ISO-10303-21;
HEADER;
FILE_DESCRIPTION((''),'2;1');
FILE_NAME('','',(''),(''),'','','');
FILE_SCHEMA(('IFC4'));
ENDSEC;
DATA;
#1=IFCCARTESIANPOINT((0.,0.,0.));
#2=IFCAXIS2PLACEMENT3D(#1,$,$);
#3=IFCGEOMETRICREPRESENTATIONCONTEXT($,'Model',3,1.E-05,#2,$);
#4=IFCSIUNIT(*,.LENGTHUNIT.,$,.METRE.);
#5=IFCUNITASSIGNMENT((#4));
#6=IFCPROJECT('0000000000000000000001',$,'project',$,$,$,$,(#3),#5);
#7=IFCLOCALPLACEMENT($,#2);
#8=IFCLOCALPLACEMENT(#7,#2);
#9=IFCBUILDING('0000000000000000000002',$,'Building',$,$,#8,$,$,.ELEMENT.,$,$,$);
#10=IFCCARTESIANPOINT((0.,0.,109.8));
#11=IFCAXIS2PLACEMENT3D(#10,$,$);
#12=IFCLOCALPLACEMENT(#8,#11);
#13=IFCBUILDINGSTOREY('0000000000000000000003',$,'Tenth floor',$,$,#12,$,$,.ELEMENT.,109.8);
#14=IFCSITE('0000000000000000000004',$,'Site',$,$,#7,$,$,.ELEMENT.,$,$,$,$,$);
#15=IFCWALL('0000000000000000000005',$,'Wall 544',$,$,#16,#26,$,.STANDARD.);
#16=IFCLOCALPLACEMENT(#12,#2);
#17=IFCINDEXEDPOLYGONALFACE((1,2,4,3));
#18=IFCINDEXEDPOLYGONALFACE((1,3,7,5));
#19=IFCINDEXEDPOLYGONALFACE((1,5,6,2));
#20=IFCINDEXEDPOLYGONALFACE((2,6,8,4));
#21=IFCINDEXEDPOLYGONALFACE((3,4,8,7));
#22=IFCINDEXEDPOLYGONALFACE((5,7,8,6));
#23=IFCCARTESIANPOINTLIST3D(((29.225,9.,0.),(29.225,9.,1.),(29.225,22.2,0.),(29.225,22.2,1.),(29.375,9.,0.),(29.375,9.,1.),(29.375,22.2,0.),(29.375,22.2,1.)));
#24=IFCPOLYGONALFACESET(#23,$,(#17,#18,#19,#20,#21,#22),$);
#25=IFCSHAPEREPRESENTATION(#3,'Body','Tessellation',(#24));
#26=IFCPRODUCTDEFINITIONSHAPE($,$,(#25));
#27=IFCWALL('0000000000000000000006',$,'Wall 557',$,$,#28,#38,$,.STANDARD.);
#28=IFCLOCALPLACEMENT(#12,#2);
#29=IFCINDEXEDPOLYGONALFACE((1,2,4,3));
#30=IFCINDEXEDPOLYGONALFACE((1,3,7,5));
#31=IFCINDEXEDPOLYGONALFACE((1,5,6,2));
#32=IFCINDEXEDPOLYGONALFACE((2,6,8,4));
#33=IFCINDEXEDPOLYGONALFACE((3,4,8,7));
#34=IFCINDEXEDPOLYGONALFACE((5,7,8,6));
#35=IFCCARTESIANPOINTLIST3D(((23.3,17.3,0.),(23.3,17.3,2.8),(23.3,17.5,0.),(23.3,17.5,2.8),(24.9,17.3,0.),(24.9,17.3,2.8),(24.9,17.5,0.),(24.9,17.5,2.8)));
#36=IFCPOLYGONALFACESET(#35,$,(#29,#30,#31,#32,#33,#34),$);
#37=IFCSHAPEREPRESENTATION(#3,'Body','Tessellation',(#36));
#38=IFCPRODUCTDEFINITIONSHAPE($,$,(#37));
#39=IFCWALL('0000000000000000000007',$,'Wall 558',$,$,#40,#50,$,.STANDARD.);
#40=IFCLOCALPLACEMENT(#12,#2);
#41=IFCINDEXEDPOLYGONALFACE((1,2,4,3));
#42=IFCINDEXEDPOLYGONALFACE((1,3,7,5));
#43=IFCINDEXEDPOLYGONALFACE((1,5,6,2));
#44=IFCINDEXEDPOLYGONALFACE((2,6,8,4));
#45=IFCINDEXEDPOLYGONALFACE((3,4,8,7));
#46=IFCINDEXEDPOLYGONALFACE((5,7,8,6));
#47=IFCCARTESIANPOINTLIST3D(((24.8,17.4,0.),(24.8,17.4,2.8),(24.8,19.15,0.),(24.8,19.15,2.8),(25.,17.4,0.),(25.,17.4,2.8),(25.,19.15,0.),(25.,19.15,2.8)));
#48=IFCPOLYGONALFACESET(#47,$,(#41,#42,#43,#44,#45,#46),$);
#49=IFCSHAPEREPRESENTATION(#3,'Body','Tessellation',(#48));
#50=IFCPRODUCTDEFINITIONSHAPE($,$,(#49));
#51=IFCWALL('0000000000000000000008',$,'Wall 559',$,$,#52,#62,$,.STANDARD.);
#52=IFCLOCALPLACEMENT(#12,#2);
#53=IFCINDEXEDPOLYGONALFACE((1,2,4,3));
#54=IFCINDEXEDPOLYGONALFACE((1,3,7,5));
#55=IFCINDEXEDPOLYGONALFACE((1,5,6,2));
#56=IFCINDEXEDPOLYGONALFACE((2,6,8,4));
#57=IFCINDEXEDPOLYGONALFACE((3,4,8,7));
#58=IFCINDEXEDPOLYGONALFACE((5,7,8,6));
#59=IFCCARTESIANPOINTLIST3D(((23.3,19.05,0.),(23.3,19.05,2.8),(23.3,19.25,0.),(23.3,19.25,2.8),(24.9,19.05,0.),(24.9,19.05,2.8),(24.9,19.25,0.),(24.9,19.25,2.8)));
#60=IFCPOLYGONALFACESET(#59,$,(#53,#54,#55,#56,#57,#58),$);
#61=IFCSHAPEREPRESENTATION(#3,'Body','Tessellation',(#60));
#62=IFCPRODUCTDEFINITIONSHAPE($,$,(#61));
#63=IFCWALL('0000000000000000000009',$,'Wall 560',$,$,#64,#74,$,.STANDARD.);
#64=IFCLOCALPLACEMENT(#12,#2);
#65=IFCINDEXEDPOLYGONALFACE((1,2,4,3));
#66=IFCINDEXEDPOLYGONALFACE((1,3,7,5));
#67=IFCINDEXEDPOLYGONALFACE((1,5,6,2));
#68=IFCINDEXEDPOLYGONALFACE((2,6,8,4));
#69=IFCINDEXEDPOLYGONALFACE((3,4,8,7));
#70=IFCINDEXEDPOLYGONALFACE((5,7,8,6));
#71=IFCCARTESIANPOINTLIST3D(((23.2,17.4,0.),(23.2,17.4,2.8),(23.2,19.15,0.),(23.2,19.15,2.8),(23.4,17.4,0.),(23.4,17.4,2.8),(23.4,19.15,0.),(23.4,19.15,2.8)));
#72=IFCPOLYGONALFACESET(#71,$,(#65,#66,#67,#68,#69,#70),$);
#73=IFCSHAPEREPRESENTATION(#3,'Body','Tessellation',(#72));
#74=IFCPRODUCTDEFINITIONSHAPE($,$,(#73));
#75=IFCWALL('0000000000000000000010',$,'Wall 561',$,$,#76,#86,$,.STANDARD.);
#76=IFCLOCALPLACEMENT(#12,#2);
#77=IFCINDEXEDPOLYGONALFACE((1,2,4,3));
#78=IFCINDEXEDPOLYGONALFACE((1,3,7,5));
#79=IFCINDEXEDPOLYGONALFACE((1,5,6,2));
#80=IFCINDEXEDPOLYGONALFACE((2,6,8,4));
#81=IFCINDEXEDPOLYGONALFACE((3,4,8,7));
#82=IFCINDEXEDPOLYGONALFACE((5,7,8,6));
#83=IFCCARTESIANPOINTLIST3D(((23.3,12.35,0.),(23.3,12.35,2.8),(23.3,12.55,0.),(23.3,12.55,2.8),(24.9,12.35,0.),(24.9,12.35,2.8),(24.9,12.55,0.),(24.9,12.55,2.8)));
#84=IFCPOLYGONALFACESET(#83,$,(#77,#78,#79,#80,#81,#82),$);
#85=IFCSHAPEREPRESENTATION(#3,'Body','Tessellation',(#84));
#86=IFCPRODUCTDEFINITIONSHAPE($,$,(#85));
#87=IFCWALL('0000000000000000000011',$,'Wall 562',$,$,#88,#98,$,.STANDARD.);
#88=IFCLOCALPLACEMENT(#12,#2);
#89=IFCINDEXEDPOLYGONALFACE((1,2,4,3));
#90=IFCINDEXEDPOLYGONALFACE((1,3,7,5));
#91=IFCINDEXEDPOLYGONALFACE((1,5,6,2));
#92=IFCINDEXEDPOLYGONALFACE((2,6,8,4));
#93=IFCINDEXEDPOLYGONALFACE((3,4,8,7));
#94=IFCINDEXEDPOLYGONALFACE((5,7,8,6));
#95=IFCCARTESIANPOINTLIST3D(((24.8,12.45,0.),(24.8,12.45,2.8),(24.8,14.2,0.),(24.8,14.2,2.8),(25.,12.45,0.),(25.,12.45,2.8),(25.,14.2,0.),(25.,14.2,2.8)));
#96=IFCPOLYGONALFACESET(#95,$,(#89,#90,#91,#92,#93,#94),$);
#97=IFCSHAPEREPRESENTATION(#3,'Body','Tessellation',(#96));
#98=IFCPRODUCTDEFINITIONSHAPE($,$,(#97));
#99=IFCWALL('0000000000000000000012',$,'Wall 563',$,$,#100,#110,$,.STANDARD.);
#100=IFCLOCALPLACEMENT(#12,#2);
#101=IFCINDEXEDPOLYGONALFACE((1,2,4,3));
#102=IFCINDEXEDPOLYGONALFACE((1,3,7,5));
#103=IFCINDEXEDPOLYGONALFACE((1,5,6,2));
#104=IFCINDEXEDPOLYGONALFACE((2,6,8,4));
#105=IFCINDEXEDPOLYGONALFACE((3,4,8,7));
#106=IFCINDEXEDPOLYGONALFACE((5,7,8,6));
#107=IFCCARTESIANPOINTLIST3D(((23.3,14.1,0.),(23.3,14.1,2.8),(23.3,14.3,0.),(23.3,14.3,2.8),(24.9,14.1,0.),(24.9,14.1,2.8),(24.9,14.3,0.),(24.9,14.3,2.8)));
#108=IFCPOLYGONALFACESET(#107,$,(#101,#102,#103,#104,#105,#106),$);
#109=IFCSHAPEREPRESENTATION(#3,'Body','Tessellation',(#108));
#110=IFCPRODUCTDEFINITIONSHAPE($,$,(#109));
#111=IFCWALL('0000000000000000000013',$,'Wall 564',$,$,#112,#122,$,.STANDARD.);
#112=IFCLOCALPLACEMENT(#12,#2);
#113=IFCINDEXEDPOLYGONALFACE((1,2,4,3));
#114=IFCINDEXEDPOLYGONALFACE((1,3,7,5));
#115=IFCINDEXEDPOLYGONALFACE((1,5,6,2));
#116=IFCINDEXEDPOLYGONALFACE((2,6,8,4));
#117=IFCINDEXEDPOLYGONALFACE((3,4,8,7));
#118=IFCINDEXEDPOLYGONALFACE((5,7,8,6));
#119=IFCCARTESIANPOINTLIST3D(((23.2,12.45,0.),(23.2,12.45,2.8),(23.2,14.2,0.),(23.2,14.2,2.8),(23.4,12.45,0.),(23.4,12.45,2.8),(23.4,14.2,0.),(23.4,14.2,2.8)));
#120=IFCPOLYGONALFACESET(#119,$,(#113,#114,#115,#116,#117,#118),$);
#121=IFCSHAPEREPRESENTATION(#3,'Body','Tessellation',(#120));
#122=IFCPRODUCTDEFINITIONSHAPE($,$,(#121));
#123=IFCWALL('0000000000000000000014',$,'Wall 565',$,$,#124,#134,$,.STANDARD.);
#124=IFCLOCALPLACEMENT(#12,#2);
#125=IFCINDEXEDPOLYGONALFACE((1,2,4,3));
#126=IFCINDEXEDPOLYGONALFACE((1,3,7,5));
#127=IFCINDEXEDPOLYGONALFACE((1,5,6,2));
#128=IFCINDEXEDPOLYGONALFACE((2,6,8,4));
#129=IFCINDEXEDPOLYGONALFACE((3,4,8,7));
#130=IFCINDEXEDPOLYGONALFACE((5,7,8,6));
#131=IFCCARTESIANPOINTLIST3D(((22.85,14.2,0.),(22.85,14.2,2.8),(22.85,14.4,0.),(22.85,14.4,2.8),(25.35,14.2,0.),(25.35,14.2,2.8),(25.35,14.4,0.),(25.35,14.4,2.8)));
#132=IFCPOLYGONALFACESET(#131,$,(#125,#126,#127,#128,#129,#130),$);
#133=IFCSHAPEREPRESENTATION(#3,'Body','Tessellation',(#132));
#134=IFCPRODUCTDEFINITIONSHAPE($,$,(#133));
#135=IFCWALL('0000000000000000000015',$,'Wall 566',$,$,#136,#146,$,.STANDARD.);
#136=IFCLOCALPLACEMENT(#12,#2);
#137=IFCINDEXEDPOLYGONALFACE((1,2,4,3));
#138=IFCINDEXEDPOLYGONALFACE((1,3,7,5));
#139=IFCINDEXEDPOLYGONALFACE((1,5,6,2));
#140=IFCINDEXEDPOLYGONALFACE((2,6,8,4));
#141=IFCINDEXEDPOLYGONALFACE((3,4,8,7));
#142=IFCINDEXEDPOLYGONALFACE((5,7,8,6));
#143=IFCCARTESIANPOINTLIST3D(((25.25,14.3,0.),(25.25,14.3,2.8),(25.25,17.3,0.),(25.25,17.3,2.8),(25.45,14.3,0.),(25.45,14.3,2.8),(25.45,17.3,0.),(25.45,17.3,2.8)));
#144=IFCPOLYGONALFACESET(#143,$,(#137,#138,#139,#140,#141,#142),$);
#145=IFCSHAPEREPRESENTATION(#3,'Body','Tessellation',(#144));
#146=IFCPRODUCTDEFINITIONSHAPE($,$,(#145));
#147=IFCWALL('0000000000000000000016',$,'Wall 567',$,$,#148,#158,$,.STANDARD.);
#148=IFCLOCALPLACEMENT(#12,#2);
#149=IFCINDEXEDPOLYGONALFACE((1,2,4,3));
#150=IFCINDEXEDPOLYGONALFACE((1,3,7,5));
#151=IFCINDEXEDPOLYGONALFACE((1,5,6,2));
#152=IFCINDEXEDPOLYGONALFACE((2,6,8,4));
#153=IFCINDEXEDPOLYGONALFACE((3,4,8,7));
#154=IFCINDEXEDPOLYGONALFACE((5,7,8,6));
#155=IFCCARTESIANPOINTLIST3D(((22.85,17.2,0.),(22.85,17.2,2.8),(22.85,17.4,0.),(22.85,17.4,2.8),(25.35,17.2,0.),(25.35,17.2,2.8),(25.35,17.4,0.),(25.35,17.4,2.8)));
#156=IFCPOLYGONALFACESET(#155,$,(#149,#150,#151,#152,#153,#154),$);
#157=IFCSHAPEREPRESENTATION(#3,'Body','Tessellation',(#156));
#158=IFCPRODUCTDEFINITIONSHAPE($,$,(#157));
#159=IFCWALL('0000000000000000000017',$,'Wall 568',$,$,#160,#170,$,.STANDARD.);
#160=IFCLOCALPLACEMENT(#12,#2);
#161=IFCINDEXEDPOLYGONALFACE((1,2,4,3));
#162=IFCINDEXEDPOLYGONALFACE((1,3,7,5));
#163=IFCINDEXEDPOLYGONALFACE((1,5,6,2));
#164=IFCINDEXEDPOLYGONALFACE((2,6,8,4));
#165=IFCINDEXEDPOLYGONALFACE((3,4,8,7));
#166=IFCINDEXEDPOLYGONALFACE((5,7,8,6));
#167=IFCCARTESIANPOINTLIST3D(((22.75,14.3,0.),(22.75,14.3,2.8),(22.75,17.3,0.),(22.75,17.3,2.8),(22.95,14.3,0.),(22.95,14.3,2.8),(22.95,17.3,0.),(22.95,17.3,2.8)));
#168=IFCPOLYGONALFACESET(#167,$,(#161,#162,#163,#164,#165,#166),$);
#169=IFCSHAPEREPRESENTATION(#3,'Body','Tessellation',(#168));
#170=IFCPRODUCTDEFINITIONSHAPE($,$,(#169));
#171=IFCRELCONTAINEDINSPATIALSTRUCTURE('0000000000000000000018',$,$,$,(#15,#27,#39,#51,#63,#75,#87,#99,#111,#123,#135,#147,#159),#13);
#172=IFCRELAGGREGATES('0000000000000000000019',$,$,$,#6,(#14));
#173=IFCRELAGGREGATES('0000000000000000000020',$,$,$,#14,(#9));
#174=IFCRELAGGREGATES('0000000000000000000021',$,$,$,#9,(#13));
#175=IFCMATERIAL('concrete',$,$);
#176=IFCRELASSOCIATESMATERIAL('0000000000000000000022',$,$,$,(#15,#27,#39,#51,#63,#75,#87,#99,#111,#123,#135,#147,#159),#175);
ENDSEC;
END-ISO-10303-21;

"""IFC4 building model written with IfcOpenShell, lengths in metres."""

from ifc_helpers import new_model, si_unit, frame, frame_2d, origin, place, context, project, spatial, rectangle, extrude, material, element, save


model = new_model("IFC4")

# Units and contexts
model_context = context("Model", 3, precision=1e-05, world=origin())
ifc_project = project(units=[si_unit("LENGTHUNIT", "METRE")], contexts=[model_context])

# Site, building, storey
site_placement = place(None, origin())
site = spatial("IfcSite", under=ifc_project, at=site_placement, Name="Site", CompositionType="ELEMENT")
building_placement = place(site_placement, origin())
building = spatial("IfcBuilding", under=site, at=building_placement, Name="Building", CompositionType="ELEMENT")
storey_placement = place(building_placement, frame((0.0, 0.0, 109.8)))
storey = spatial("IfcBuildingStorey", under=building, at=storey_placement, Name="Tenth floor", CompositionType="ELEMENT", Elevation=109.8)

# Shared definitions
ifc_material = material(Name="concrete")

# Walls
wall_1_placement = place(storey_placement, frame((29.3, 22.2, 0.0), z_axis=(0.0, 0.0, 1.0), x_axis=(0.0, -1.0, 0.0)))
element("IfcWall", 1, at=wall_1_placement, inside=storey, material=ifc_material, Name="Wall 544", PredefinedType="STANDARD", context=model_context, shape_type="SweptSolid", body=[
    extrude(rectangle(XDim=13.2, YDim=0.15, at=frame_2d((6.6, 0.0))), origin(), (0.0, 0.0, 1.0), 1.0),
])
wall_2_placement = place(storey_placement, frame((23.3, 17.4, 0.0), z_axis=(0.0, 0.0, 1.0), x_axis=(1.0, 0.0, 0.0)))
element("IfcWall", 2, at=wall_2_placement, inside=storey, material=ifc_material, Name="Wall 557", PredefinedType="STANDARD", context=model_context, shape_type="SweptSolid", body=[
    extrude(rectangle(XDim=1.6, YDim=0.2, at=frame_2d((0.8, 0.0))), origin(), (0.0, 0.0, 1.0), 2.8),
])
wall_3_placement = place(storey_placement, frame((24.9, 17.4, 0.0), z_axis=(0.0, 0.0, 1.0), x_axis=(0.0, 1.0, 0.0)))
element("IfcWall", 3, at=wall_3_placement, inside=storey, material=ifc_material, Name="Wall 558", PredefinedType="STANDARD", context=model_context, shape_type="SweptSolid", body=[
    extrude(rectangle(XDim=1.75, YDim=0.2, at=frame_2d((0.875, 0.0))), origin(), (0.0, 0.0, 1.0), 2.8),
])
wall_4_placement = place(storey_placement, frame((24.9, 19.15, 0.0), z_axis=(0.0, 0.0, 1.0), x_axis=(-1.0, 0.0, 0.0)))
element("IfcWall", 4, at=wall_4_placement, inside=storey, material=ifc_material, Name="Wall 559", PredefinedType="STANDARD", context=model_context, shape_type="SweptSolid", body=[
    extrude(rectangle(XDim=1.6, YDim=0.2, at=frame_2d((0.8, 0.0))), origin(), (0.0, 0.0, 1.0), 2.8),
])
wall_5_placement = place(storey_placement, frame((23.3, 19.15, 0.0), z_axis=(0.0, 0.0, 1.0), x_axis=(0.0, -1.0, 0.0)))
element("IfcWall", 5, at=wall_5_placement, inside=storey, material=ifc_material, Name="Wall 560", PredefinedType="STANDARD", context=model_context, shape_type="SweptSolid", body=[
    extrude(rectangle(XDim=1.75, YDim=0.2, at=frame_2d((0.875, 0.0))), origin(), (0.0, 0.0, 1.0), 2.8),
])
wall_6_placement = place(storey_placement, frame((23.3, 12.45, 0.0), z_axis=(0.0, 0.0, 1.0), x_axis=(1.0, 0.0, 0.0)))
element("IfcWall", 6, at=wall_6_placement, inside=storey, material=ifc_material, Name="Wall 561", PredefinedType="STANDARD", context=model_context, shape_type="SweptSolid", body=[
    extrude(rectangle(XDim=1.6, YDim=0.2, at=frame_2d((0.8, 0.0))), origin(), (0.0, 0.0, 1.0), 2.8),
])
wall_7_placement = place(storey_placement, frame((24.9, 12.45, 0.0), z_axis=(0.0, 0.0, 1.0), x_axis=(0.0, 1.0, 0.0)))
element("IfcWall", 7, at=wall_7_placement, inside=storey, material=ifc_material, Name="Wall 562", PredefinedType="STANDARD", context=model_context, shape_type="SweptSolid", body=[
    extrude(rectangle(XDim=1.75, YDim=0.2, at=frame_2d((0.875, 0.0))), origin(), (0.0, 0.0, 1.0), 2.8),
])
wall_8_placement = place(storey_placement, frame((24.9, 14.2, 0.0), z_axis=(0.0, 0.0, 1.0), x_axis=(-1.0, 0.0, 0.0)))
element("IfcWall", 8, at=wall_8_placement, inside=storey, material=ifc_material, Name="Wall 563", PredefinedType="STANDARD", context=model_context, shape_type="SweptSolid", body=[
    extrude(rectangle(XDim=1.6, YDim=0.2, at=frame_2d((0.8, 0.0))), origin(), (0.0, 0.0, 1.0), 2.8),
])
wall_9_placement = place(storey_placement, frame((23.3, 14.2, 0.0), z_axis=(0.0, 0.0, 1.0), x_axis=(0.0, -1.0, 0.0)))
element("IfcWall", 9, at=wall_9_placement, inside=storey, material=ifc_material, Name="Wall 564", PredefinedType="STANDARD", context=model_context, shape_type="SweptSolid", body=[
    extrude(rectangle(XDim=1.75, YDim=0.2, at=frame_2d((0.875, 0.0))), origin(), (0.0, 0.0, 1.0), 2.8),
])
wall_10_placement = place(storey_placement, frame((22.85, 14.3, 0.0), z_axis=(0.0, 0.0, 1.0), x_axis=(1.0, 0.0, 0.0)))
element("IfcWall", 10, at=wall_10_placement, inside=storey, material=ifc_material, Name="Wall 565", PredefinedType="STANDARD", context=model_context, shape_type="SweptSolid", body=[
    extrude(rectangle(XDim=2.5, YDim=0.2, at=frame_2d((1.25, 0.0))), origin(), (0.0, 0.0, 1.0), 2.8),
])
wall_11_placement = place(storey_placement, frame((25.35, 14.3, 0.0), z_axis=(0.0, 0.0, 1.0), x_axis=(0.0, 1.0, 0.0)))
element("IfcWall", 11, at=wall_11_placement, inside=storey, material=ifc_material, Name="Wall 566", PredefinedType="STANDARD", context=model_context, shape_type="SweptSolid", body=[
    extrude(rectangle(XDim=3.0, YDim=0.2, at=frame_2d((1.5, 0.0))), origin(), (0.0, 0.0, 1.0), 2.8),
])
wall_12_placement = place(storey_placement, frame((25.35, 17.3, 0.0), z_axis=(0.0, 0.0, 1.0), x_axis=(-1.0, 0.0, 0.0)))
element("IfcWall", 12, at=wall_12_placement, inside=storey, material=ifc_material, Name="Wall 567", PredefinedType="STANDARD", context=model_context, shape_type="SweptSolid", body=[
    extrude(rectangle(XDim=2.5, YDim=0.2, at=frame_2d((1.25, 0.0))), origin(), (0.0, 0.0, 1.0), 2.8),
])
wall_13_placement = place(storey_placement, frame((22.85, 17.3, 0.0), z_axis=(0.0, 0.0, 1.0), x_axis=(0.0, -1.0, 0.0)))
element("IfcWall", 13, at=wall_13_placement, inside=storey, material=ifc_material, Name="Wall 568", PredefinedType="STANDARD", context=model_context, shape_type="SweptSolid", body=[
    extrude(rectangle(XDim=3.0, YDim=0.2, at=frame_2d((1.5, 0.0))), origin(), (0.0, 0.0, 1.0), 2.8),
])

save(model, "model.ifc")
